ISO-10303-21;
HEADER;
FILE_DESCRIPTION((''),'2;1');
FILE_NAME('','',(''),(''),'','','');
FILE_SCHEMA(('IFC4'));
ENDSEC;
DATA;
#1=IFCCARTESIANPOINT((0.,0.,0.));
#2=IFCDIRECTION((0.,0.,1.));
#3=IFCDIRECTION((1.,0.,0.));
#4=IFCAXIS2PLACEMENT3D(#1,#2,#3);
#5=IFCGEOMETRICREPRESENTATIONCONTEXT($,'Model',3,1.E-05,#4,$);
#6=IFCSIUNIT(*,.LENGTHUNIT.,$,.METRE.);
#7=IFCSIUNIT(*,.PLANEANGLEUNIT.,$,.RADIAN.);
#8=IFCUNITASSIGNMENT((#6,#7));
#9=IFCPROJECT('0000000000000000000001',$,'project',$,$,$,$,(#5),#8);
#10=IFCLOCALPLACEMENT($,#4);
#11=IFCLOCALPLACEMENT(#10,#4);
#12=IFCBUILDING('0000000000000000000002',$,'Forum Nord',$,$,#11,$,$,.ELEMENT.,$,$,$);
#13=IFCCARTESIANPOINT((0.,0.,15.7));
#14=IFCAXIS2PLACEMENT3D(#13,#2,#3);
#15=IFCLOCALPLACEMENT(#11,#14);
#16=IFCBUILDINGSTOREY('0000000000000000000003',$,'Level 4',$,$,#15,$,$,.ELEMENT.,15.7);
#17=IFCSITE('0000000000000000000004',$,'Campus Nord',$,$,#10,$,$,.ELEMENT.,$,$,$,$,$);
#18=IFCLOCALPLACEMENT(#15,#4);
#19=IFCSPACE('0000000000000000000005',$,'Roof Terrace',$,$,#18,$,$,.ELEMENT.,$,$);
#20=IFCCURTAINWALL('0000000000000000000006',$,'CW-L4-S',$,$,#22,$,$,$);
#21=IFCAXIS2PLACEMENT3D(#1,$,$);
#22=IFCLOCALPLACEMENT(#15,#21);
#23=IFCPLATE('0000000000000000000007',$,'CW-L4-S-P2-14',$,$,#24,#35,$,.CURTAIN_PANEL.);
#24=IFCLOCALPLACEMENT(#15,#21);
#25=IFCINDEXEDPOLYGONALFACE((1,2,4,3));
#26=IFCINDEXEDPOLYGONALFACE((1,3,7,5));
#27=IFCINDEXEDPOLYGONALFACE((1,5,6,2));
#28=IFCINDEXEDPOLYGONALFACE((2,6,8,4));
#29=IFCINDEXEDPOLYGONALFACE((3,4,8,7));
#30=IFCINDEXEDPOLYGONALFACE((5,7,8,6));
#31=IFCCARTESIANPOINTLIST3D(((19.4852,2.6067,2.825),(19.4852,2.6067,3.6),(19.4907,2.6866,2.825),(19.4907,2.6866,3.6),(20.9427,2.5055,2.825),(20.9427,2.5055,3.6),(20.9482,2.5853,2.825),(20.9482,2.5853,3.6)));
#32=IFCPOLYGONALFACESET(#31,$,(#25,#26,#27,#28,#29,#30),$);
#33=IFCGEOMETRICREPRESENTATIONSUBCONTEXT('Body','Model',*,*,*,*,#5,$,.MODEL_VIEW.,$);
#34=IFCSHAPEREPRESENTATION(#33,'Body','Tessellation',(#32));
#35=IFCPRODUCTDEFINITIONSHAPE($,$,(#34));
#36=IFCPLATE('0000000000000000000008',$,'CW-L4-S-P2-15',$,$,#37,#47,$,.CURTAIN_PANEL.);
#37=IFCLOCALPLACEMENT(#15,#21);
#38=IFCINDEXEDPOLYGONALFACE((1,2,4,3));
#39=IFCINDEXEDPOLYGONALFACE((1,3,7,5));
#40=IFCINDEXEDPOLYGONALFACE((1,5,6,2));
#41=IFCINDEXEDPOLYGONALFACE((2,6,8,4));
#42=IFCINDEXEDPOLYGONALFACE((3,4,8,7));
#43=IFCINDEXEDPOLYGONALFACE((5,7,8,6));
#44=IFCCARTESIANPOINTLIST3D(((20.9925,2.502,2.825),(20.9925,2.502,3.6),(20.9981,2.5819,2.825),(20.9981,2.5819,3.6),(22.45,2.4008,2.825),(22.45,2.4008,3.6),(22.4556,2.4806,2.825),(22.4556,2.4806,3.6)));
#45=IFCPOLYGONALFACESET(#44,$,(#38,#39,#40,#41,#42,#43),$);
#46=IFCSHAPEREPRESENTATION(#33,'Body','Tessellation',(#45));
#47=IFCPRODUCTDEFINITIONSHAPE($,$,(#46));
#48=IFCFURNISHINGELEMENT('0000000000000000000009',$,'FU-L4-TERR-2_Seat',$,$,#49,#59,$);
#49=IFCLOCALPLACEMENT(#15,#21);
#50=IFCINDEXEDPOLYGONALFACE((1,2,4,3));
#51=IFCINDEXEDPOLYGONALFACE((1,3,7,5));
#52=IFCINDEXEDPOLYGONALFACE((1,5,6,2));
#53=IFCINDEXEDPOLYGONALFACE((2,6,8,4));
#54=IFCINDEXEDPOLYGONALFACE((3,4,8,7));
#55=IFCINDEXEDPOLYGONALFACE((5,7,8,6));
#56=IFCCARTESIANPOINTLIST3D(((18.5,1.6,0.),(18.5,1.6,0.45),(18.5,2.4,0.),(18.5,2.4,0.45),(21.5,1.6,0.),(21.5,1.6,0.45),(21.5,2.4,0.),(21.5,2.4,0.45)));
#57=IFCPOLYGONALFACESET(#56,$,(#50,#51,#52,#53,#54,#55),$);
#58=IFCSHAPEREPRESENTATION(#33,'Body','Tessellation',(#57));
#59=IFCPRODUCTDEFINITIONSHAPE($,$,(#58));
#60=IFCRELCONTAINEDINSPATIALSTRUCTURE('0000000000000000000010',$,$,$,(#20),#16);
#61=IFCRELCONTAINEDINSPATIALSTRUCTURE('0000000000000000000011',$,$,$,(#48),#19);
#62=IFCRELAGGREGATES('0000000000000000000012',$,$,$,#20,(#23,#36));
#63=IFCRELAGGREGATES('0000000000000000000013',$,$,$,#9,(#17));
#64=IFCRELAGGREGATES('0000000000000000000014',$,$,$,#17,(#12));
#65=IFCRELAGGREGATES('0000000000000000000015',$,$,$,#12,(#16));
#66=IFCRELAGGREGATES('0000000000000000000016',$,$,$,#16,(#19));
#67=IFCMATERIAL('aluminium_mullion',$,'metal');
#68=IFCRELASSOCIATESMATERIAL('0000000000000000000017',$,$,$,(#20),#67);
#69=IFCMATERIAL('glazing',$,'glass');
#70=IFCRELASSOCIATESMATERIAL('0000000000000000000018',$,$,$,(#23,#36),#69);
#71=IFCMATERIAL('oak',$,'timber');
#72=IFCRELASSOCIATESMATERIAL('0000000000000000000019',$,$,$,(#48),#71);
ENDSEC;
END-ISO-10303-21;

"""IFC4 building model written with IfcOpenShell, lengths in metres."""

from ifc_helpers import new_model, si_unit, frame, frame_2d, origin_with_axes, place, context, subcontext, project, spatial, rectangle, extrude, material, element, aggregate, save


model = new_model("IFC4")

# Units and contexts
model_context = context("Model", 3, precision=1e-05, world=origin_with_axes())
body_context = subcontext(model_context, "Body", "Model", "MODEL_VIEW")
ifc_project = project(units=[si_unit("LENGTHUNIT", "METRE"), si_unit("PLANEANGLEUNIT", "RADIAN")], contexts=[model_context])

# Site, building, storey
site_placement = place(None, origin_with_axes())
site = spatial("IfcSite", under=ifc_project, at=site_placement, Name="Campus Nord", CompositionType="ELEMENT")
building_placement = place(site_placement, origin_with_axes())
building = spatial("IfcBuilding", under=site, at=building_placement, Name="Forum Nord", CompositionType="ELEMENT")
storey_placement = place(building_placement, frame((0.0, 0.0, 15.7), z_axis=(0.0, 0.0, 1.0), x_axis=(1.0, 0.0, 0.0)))
storey = spatial("IfcBuildingStorey", under=building, at=storey_placement, Name="Level 4", CompositionType="ELEMENT", Elevation=15.7)

# Curtain wall, plates
ifc_material_1 = material(Name="aluminium_mullion", Category="metal")
curtain_wall_placement = place(storey_placement, origin_with_axes())
curtain_wall = element("IfcCurtainWall", 1, at=curtain_wall_placement, inside=storey, material=ifc_material_1, Name="CW-L4-S")
ifc_material_2 = material(Name="glazing", Category="glass")
plate_1_placement = place(storey_placement, frame((19.488, 2.6467, 2.825), z_axis=(0.0, 0.0, 1.0), x_axis=(0.9976, -0.06929, 0.0)))
plate_1 = element("IfcPlate", 2, at=plate_1_placement, material=ifc_material_2, Name="CW-L4-S-P2-14", PredefinedType="CURTAIN_PANEL", context=body_context, shape_type="SweptSolid", body=[
    extrude(rectangle(XDim=1.461, YDim=0.08, at=frame_2d((0.7305, 0.0), x_axis=(1.0, 0.0))), origin_with_axes(), (0.0, 0.0, 1.0), 0.775),
])
plate_2_placement = place(storey_placement, frame((20.9953, 2.5419, 2.825), z_axis=(0.0, 0.0, 1.0), x_axis=(0.9976, -0.06929, 0.0)))
plate_2 = element("IfcPlate", 3, at=plate_2_placement, material=ifc_material_2, Name="CW-L4-S-P2-15", PredefinedType="CURTAIN_PANEL", context=body_context, shape_type="SweptSolid", body=[
    extrude(rectangle(XDim=1.461, YDim=0.08, at=frame_2d((0.7305, 0.0), x_axis=(1.0, 0.0))), origin_with_axes(), (0.0, 0.0, 1.0), 0.775),
])
aggregate(curtain_wall, [plate_1, plate_2])

# Shared definitions
ifc_material_3 = material(Name="oak", Category="timber")

# Shared definitions
space_1_placement = place(storey_placement, origin_with_axes())
space_1 = spatial("IfcSpace", under=storey, at=space_1_placement, Name="Roof Terrace", CompositionType="ELEMENT")

# Furnishing element
furnishing_1_placement = place(storey_placement, frame((18.5, 1.6, 0.0), z_axis=(0.0, 0.0, 1.0), x_axis=(1.0, 0.0, 0.0)))
element("IfcFurnishingElement", 4, at=furnishing_1_placement, inside=space_1, material=ifc_material_3, Name="FU-L4-TERR-2_Seat", context=body_context, shape_type="SweptSolid", body=[
    extrude(rectangle(XDim=3.0, YDim=0.8, at=frame_2d((1.5, 0.4), x_axis=(1.0, 0.0))), origin_with_axes(), (0.0, 0.0, 1.0), 0.45),
])

save(model, "model.ifc")
